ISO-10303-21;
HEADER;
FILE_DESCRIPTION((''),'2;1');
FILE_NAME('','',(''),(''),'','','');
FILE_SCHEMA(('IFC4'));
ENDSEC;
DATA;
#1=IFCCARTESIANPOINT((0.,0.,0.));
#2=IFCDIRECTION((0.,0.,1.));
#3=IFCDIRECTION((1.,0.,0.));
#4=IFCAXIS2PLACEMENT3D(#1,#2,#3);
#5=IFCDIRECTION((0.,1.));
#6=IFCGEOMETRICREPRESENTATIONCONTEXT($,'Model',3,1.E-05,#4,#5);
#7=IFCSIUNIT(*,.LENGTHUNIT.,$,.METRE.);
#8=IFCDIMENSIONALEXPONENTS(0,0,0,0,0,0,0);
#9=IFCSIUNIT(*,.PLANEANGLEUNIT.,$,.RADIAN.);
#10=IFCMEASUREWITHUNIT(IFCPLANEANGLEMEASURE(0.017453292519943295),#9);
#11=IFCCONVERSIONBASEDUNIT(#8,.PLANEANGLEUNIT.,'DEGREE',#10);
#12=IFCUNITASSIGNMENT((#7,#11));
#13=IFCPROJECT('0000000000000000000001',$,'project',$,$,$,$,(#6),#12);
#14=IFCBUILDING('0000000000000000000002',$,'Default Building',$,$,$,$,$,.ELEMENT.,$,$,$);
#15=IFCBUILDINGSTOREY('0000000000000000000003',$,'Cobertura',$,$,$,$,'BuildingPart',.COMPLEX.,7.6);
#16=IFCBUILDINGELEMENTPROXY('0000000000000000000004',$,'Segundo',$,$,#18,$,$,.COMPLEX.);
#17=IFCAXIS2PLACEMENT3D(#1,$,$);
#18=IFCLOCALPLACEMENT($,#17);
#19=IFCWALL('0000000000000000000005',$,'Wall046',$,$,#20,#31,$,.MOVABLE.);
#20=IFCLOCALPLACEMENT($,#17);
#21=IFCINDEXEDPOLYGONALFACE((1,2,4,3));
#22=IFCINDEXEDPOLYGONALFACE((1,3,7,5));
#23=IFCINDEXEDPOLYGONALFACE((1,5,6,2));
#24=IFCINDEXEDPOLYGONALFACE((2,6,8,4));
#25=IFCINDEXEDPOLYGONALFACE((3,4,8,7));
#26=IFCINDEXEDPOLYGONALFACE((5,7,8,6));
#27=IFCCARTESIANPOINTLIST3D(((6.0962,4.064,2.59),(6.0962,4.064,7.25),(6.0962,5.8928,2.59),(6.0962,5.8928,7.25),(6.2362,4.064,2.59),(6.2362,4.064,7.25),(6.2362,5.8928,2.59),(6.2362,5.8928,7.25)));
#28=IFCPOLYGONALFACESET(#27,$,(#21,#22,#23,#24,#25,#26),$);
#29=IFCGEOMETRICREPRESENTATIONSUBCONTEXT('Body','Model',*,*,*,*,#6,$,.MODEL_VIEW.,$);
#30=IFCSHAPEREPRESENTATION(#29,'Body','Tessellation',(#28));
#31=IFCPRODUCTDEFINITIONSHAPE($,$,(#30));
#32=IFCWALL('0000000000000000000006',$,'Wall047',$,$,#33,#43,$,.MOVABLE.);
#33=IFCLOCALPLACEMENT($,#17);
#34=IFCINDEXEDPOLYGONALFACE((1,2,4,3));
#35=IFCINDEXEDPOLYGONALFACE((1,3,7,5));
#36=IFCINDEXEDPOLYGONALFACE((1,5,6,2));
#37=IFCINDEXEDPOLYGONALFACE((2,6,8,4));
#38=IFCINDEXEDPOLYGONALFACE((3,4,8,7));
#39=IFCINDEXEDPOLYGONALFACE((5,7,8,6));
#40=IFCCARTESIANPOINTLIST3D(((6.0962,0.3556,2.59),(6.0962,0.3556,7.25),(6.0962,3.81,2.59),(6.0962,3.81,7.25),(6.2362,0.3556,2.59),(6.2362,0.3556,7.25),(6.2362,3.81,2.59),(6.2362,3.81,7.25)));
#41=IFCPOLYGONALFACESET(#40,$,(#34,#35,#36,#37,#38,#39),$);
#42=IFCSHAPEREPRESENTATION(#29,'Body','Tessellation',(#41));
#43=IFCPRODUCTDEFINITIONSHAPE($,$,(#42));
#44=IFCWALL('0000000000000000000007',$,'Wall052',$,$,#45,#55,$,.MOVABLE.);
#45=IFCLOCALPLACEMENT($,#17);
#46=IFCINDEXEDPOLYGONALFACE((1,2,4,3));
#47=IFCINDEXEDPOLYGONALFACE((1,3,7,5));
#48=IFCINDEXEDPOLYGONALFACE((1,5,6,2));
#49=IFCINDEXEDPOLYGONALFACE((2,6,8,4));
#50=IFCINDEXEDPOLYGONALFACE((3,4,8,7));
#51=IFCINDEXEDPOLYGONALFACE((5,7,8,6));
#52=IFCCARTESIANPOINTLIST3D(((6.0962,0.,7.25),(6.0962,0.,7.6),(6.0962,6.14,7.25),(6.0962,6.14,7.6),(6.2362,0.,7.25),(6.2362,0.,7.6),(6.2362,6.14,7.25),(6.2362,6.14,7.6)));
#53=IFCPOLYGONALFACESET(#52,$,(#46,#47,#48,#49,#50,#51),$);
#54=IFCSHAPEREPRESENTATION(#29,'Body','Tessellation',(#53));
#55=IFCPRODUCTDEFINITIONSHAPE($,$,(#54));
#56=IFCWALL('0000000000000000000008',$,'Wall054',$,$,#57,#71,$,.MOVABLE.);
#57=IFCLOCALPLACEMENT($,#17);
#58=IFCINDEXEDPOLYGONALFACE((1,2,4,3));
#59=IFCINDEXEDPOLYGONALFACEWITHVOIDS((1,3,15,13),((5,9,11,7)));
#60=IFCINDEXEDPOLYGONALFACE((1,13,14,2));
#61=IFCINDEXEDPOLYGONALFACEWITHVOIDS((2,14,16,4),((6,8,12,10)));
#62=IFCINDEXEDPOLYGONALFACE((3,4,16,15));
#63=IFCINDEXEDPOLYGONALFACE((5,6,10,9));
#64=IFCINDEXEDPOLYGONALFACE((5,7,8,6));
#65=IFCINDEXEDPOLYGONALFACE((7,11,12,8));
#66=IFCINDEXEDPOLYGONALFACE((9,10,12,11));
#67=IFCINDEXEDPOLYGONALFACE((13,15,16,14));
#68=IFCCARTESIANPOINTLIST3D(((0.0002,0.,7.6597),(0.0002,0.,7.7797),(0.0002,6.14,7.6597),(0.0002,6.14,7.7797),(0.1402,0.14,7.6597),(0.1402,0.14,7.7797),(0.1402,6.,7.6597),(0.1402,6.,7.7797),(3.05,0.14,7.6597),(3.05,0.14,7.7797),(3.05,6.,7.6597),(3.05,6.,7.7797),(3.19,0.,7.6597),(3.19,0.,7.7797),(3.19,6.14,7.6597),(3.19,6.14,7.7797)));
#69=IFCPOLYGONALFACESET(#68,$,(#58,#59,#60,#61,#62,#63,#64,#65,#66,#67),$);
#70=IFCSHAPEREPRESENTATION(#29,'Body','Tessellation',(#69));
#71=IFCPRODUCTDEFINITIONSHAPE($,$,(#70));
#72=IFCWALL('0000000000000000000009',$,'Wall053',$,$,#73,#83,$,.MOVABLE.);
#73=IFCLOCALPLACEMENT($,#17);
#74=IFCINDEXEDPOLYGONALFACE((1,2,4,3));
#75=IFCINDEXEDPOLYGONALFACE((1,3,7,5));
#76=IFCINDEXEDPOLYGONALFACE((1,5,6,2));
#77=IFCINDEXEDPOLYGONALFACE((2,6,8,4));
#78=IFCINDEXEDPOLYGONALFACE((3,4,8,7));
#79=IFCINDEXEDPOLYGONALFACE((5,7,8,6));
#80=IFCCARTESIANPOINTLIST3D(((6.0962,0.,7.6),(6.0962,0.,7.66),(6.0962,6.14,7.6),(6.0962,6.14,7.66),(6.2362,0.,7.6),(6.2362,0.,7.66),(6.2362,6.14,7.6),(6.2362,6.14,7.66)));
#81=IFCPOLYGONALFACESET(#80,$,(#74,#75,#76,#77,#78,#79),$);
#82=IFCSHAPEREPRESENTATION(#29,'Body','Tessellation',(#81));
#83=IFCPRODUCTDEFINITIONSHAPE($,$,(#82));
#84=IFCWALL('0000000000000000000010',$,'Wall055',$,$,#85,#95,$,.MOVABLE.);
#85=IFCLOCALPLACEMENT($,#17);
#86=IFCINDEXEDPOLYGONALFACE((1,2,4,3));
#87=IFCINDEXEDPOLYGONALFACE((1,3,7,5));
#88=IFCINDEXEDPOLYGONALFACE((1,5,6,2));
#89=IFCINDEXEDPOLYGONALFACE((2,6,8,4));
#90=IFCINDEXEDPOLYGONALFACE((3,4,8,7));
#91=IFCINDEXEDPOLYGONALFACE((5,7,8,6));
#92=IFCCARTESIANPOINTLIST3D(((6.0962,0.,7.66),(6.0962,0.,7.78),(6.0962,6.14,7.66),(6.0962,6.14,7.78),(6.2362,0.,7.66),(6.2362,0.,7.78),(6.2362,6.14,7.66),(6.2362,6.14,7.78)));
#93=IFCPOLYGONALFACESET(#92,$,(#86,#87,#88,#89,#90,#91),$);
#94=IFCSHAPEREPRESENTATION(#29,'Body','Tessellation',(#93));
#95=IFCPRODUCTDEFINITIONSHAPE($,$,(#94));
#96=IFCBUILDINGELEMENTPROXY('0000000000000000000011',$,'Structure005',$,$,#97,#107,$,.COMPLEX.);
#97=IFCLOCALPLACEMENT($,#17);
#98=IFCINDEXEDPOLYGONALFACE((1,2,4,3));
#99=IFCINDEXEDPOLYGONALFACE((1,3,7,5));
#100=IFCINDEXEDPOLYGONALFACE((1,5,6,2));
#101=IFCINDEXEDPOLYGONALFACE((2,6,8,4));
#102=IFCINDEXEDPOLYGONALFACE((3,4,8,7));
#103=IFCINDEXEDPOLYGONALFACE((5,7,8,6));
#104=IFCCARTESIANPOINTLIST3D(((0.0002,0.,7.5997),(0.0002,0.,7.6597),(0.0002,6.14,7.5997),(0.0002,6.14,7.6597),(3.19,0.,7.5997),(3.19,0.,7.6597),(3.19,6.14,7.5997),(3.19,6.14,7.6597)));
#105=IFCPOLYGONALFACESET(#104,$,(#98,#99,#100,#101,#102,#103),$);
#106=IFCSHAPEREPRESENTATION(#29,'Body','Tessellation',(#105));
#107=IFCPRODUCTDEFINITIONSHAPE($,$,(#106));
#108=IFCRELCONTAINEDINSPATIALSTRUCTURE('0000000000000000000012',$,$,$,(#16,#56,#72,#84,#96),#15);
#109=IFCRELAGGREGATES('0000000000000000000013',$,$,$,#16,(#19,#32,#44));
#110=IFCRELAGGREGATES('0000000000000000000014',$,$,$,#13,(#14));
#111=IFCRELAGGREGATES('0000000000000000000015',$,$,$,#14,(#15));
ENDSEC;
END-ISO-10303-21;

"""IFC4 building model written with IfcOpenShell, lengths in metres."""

from ifc_helpers import new_model, entity, si_unit, converted_unit, direction, frame, frame_2d, origin_with_axes, origin_2d_with_axis, place, context, subcontext, project, spatial, polyline, rectangle, outline, extrude, element, aggregate, save


model = new_model("IFC4")

# Units and contexts
model_context = context("Model", 3, precision=1e-05, world=origin_with_axes(), true_north=direction((0.0, 1.0)))
body_context = subcontext(model_context, "Body", "Model", "MODEL_VIEW")
ifc_project = project(units=[si_unit("LENGTHUNIT", "METRE"), converted_unit("PLANEANGLEUNIT", "DEGREE", entity("IfcPlaneAngleMeasure", 0.017453292519943295), si_unit("PLANEANGLEUNIT", "RADIAN"), dimensions=[0, 0, 0, 0, 0, 0, 0])], contexts=[model_context])

# Building, storey
building = spatial("IfcBuilding", under=ifc_project, Name="Default Building", CompositionType="ELEMENT")
storey = spatial("IfcBuildingStorey", under=building, Name="Cobertura", LongName="BuildingPart", CompositionType="COMPLEX", Elevation=7.6)

# Building element proxy, walls
proxy_1 = element("IfcBuildingElementProxy", 1, inside=storey, Name="Segundo", PredefinedType="COMPLEX")
placement = place(None, origin_with_axes())
wall_1 = element("IfcWall", 2, at=placement, Name="Wall046", PredefinedType="MOVABLE", context=body_context, shape_type="SweptSolid", body=[
    extrude(rectangle(XDim=1.8288, YDim=0.14, at=frame_2d((0.0, 0.0), x_axis=(0.0, -1.0))), frame((6.1662, 4.9784, 2.59), z_axis=(0.0, 0.0, 1.0), x_axis=(1.0, 0.0, 0.0)), (0.0, 0.0, 1.0), 4.66),
])
wall_2 = element("IfcWall", 3, at=placement, Name="Wall047", PredefinedType="MOVABLE", context=body_context, shape_type="SweptSolid", body=[
    extrude(rectangle(XDim=3.4544, YDim=0.14, at=frame_2d((0.0, 0.0), x_axis=(0.0, -1.0))), frame((6.1662, 2.0828, 2.59), z_axis=(0.0, 0.0, 1.0), x_axis=(1.0, 0.0, 0.0)), (0.0, 0.0, 1.0), 4.66),
])
wall_3 = element("IfcWall", 4, at=placement, Name="Wall052", PredefinedType="MOVABLE", context=body_context, shape_type="SweptSolid", body=[
    extrude(rectangle(XDim=6.14, YDim=0.14, at=frame_2d((0.0, 0.0), x_axis=(0.0, 1.0))), frame((6.1662, 3.07, 7.25), z_axis=(0.0, 0.0, 1.0), x_axis=(1.0, 0.0, 0.0)), (0.0, 0.0, 1.0), 0.35),
])
aggregate(proxy_1, [wall_1, wall_2, wall_3])

# Walls
element("IfcWall", 5, at=placement, inside=storey, Name="Wall054", PredefinedType="MOVABLE", context=body_context, shape_type="SweptSolid", body=[
    extrude(outline(polyline([(-1.5949, -3.07), (1.5949, -3.07), (1.5949, 3.07), (-1.5949, 3.07), (-1.5949, -3.07)]), holes=[polyline([(1.4549, -2.93), (1.4549, 2.93), (-1.4549, 2.93), (-1.4549, -2.93), (1.4549, -2.93)])]), frame((1.5951, 3.07, 7.6597), z_axis=(0.0, 0.0, 1.0), x_axis=(1.0, 0.0, 0.0)), (0.0, 0.0, 1.0), 0.12),
])
element("IfcWall", 6, at=placement, inside=storey, Name="Wall053", PredefinedType="MOVABLE", context=body_context, shape_type="SweptSolid", body=[
    extrude(rectangle(XDim=6.14, YDim=0.14, at=frame_2d((0.0, 0.0), x_axis=(0.0, 1.0))), frame((6.1662, 3.07, 7.6), z_axis=(0.0, 0.0, 1.0), x_axis=(1.0, 0.0, 0.0)), (0.0, 0.0, 1.0), 0.06),
])
element("IfcWall", 7, at=placement, inside=storey, Name="Wall055", PredefinedType="MOVABLE", context=body_context, shape_type="SweptSolid", body=[
    extrude(rectangle(XDim=6.14, YDim=0.14, at=frame_2d((0.0, 0.0), x_axis=(0.0, 1.0))), frame((6.1662, 3.07, 7.66), z_axis=(0.0, 0.0, 1.0), x_axis=(1.0, 0.0, 0.0)), (0.0, 0.0, 1.0), 0.12),
])

# Building element proxy
element("IfcBuildingElementProxy", 8, at=placement, inside=storey, Name="Structure005", PredefinedType="COMPLEX", context=body_context, shape_type="SweptSolid", body=[
    extrude(rectangle(XDim=3.1898, YDim=6.14, at=origin_2d_with_axis()), frame((1.5951, 3.07, 7.5997), z_axis=(0.0, 0.0, 1.0), x_axis=(1.0, 0.0, 0.0)), (0.0, 0.0, 1.0), 0.06),
])

save(model, "model.ifc")
